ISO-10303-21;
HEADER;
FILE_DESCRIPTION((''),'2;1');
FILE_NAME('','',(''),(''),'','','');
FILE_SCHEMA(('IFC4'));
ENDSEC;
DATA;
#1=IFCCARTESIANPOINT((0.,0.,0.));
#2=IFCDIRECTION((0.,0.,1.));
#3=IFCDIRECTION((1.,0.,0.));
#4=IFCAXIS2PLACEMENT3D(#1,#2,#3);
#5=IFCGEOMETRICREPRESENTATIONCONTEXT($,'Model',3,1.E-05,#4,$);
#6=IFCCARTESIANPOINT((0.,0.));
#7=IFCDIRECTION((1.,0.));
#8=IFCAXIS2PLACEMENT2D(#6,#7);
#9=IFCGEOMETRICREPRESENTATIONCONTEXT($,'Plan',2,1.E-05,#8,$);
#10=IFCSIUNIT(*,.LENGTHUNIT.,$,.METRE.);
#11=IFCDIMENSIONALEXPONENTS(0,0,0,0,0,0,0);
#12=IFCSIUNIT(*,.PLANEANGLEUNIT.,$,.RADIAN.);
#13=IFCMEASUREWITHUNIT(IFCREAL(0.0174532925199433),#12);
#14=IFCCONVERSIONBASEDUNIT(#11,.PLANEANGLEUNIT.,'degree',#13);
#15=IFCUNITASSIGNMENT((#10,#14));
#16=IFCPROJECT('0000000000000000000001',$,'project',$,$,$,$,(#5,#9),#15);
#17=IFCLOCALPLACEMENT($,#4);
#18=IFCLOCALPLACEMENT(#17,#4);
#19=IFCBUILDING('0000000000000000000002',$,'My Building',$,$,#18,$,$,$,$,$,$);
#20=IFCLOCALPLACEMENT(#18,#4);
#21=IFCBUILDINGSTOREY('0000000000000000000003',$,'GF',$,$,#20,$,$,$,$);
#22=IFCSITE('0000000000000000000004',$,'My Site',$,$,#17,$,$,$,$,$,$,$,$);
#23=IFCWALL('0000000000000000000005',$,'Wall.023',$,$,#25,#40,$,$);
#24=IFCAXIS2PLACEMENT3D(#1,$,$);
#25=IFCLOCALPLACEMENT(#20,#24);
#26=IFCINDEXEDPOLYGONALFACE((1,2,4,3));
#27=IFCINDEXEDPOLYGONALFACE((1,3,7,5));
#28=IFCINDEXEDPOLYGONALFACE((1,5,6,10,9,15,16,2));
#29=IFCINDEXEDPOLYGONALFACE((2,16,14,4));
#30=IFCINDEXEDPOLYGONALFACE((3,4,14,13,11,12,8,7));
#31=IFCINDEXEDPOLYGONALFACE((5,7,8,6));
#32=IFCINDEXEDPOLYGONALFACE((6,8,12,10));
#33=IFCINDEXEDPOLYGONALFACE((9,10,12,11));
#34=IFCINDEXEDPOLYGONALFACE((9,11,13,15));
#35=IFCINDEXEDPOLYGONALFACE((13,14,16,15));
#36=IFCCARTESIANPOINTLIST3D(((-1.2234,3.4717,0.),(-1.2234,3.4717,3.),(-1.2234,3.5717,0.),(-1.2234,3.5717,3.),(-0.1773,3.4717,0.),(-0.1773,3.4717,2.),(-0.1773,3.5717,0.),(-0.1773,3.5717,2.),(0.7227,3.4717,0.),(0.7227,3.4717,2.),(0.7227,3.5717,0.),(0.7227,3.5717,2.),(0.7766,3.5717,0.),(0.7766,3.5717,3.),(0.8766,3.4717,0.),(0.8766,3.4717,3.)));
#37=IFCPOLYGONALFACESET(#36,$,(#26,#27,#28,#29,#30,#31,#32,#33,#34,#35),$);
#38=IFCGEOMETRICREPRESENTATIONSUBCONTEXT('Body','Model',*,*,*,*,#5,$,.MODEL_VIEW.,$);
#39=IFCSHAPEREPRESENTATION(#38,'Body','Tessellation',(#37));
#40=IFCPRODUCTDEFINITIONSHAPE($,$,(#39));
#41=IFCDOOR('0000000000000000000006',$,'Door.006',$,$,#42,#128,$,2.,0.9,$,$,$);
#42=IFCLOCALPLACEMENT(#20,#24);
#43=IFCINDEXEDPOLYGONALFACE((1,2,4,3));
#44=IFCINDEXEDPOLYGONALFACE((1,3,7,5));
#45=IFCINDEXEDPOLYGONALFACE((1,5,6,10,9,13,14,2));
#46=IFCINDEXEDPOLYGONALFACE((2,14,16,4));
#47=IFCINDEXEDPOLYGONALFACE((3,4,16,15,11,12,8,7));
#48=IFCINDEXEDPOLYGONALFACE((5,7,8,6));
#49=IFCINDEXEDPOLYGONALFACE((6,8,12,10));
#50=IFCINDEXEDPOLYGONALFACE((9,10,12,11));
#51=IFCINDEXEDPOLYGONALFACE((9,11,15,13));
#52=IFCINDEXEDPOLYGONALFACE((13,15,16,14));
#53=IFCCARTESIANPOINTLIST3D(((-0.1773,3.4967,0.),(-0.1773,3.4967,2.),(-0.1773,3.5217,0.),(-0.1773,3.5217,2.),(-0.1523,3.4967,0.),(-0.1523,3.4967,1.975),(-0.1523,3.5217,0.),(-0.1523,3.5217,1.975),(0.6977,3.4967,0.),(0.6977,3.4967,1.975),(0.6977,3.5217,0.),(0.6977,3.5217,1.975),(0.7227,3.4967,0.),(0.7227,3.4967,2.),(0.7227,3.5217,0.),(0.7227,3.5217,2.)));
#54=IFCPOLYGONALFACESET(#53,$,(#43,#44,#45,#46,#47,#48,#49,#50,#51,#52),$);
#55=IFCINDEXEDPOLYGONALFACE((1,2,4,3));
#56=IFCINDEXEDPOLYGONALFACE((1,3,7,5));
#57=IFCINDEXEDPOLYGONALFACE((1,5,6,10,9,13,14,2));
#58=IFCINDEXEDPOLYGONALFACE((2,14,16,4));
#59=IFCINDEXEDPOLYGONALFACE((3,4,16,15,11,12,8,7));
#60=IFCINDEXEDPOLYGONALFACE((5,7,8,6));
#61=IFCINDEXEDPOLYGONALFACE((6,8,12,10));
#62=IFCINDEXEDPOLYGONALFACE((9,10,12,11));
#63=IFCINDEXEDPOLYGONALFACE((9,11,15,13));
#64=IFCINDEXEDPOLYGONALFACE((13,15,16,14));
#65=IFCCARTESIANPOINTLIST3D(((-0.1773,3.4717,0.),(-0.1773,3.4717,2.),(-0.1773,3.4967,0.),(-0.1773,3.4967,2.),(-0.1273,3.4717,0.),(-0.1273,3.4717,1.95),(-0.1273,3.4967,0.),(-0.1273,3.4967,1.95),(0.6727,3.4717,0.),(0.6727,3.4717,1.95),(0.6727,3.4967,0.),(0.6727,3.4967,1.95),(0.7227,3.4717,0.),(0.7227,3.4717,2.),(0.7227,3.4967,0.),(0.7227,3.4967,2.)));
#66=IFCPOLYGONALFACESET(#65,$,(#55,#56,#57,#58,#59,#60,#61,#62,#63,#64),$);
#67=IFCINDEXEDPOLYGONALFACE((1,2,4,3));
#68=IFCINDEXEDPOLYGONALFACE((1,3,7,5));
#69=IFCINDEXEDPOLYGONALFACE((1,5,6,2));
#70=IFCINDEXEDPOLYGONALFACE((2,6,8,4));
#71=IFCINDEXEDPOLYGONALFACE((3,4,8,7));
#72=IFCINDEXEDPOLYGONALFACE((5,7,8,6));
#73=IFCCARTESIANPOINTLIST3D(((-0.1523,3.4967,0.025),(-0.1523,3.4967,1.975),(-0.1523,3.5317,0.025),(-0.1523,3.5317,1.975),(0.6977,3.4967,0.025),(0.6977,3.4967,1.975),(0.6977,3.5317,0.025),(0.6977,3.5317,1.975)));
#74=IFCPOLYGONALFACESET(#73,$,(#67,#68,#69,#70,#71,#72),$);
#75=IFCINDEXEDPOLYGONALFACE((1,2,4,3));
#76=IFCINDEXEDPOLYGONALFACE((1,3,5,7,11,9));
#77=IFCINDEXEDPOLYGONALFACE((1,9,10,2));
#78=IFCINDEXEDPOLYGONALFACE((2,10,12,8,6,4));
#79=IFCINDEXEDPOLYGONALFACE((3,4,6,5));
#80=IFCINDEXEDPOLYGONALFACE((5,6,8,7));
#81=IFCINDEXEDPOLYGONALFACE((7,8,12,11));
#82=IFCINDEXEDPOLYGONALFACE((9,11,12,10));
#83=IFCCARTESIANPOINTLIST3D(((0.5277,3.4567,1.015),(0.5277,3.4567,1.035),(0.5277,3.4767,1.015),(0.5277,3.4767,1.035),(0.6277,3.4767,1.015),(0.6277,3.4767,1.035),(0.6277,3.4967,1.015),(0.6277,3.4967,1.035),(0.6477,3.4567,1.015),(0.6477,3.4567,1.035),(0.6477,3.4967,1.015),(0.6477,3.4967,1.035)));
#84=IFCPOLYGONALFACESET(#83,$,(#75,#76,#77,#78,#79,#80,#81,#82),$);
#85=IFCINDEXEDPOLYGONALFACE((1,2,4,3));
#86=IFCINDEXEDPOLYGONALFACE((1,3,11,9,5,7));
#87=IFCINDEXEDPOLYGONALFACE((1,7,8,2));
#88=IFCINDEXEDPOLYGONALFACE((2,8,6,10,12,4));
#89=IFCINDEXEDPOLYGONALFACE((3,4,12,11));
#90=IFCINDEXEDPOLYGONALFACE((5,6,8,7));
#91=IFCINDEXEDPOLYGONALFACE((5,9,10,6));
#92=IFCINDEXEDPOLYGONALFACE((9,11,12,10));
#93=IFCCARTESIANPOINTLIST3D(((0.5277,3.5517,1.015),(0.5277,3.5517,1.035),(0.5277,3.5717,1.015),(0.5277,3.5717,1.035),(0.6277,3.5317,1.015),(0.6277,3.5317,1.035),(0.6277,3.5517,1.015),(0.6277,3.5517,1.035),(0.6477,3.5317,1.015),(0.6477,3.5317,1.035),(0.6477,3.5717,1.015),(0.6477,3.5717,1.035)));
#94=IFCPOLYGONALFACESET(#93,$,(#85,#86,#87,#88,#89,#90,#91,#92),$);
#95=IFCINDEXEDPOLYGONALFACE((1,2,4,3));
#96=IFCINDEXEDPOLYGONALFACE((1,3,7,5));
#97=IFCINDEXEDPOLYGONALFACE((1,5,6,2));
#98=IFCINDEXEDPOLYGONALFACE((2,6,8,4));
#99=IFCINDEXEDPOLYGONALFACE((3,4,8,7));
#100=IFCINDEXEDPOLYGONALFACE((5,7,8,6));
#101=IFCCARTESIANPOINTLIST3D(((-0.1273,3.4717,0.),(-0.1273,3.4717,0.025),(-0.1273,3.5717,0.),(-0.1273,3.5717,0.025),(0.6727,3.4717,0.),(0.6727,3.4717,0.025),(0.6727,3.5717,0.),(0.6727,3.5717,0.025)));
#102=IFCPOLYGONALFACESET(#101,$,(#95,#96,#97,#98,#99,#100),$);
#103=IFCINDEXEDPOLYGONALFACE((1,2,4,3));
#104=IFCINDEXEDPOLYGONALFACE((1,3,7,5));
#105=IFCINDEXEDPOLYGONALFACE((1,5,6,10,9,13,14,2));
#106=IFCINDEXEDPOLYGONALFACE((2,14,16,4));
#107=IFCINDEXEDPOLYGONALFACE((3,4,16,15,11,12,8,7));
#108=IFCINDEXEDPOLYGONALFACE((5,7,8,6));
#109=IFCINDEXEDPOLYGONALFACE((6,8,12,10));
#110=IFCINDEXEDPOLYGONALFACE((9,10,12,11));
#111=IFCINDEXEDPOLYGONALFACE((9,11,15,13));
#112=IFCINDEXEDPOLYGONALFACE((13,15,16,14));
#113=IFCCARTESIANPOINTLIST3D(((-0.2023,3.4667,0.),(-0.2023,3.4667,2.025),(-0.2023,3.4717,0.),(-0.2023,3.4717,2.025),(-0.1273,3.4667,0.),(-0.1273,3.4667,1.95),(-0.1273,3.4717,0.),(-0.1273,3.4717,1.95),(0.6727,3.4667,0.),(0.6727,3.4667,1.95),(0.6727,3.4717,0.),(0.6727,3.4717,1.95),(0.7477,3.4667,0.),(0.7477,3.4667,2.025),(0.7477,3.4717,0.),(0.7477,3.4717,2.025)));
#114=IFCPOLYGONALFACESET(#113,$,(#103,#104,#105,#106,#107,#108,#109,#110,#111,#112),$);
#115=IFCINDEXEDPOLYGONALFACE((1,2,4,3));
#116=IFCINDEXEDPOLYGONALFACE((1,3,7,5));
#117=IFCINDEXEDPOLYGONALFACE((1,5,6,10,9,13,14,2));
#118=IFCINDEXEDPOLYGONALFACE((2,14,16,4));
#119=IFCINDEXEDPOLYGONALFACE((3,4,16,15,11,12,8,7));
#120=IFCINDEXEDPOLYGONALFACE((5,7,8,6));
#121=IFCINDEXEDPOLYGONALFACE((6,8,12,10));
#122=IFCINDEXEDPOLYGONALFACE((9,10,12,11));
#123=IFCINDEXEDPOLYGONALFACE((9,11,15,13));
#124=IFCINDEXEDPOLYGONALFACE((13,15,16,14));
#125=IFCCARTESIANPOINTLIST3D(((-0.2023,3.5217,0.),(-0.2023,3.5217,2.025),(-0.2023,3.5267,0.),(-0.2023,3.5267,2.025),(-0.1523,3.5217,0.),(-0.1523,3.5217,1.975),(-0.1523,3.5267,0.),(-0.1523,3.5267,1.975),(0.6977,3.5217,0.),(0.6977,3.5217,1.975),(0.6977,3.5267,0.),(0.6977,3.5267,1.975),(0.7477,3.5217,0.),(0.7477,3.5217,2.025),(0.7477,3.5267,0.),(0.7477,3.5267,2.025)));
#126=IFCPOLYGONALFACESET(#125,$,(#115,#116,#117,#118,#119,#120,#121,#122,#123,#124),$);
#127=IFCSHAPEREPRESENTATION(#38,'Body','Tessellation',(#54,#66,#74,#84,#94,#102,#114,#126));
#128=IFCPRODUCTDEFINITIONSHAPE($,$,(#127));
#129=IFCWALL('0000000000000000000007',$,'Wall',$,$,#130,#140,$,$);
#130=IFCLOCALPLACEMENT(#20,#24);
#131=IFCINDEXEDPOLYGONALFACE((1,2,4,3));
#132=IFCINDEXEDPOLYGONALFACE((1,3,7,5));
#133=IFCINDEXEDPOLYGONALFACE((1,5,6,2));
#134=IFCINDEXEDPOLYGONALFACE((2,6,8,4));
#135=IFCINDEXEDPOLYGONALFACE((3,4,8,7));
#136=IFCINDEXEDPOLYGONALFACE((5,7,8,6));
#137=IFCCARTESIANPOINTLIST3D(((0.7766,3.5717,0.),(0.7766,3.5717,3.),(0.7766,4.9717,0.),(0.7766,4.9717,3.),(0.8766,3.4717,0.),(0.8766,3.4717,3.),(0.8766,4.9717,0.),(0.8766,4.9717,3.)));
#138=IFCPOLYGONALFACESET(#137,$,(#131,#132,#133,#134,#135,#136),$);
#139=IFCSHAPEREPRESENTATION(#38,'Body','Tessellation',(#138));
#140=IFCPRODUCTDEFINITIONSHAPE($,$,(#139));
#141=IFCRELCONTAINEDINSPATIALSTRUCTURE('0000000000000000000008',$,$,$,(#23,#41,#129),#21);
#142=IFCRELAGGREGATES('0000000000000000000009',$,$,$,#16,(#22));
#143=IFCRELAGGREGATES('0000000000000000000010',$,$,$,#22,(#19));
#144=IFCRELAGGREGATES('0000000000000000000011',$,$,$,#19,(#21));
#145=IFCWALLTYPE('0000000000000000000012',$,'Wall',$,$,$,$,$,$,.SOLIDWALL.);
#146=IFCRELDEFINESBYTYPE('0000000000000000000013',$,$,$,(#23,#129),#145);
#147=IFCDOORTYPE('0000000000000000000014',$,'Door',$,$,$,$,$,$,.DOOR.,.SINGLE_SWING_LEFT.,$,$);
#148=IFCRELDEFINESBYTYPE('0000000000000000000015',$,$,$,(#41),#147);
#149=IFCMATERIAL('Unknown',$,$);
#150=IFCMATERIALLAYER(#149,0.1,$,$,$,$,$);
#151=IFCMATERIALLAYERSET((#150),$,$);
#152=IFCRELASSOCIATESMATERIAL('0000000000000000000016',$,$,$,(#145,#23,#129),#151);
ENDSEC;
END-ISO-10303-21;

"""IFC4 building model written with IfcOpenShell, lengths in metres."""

from ifc_helpers import new_model, entity, si_unit, converted_unit, frame, origin_with_axes, origin_2d_with_axis, place, context, subcontext, project, spatial, line, indexed_curve, outline, extrude, shape, source, transform, mapped, material, layer, layer_set, layer_usage, type_object, type_shapes, element, fill, save


model = new_model("IFC4")

# Units and contexts
model_context = context("Model", 3, precision=1e-05, world=origin_with_axes())
plan_context = context("Plan", 2, precision=1e-05, world=origin_2d_with_axis())
body_context_1 = subcontext(model_context, "Body", "Model", "MODEL_VIEW")
body_context_2 = subcontext(plan_context, "Body", "Plan", "PLAN_VIEW")
ifc_project = project(units=[si_unit("LENGTHUNIT", "METRE"), converted_unit("PLANEANGLEUNIT", "degree", entity("IfcReal", 0.0174532925199433), si_unit("PLANEANGLEUNIT", "RADIAN"), dimensions=[0, 0, 0, 0, 0, 0, 0])], contexts=[model_context, plan_context])

# Site, building, storey
site_placement = place(None, origin_with_axes())
site = spatial("IfcSite", under=ifc_project, at=site_placement, Name="My Site")
building_placement = place(site_placement, origin_with_axes())
building = spatial("IfcBuilding", under=site, at=building_placement, Name="My Building")
storey_placement = place(building_placement, origin_with_axes())
storey = spatial("IfcBuildingStorey", under=building, at=storey_placement, Name="GF")

# Shared definitions
ifc_material = material(Name="Unknown")

# Shared definitions
ifc_layer = layer(ifc_material, 0.1)
ifc_layer_set = layer_set([ifc_layer])
wall_type = type_object("IfcWallType", Name="Wall", PredefinedType="SOLIDWALL", material=ifc_layer_set)

# Shared definitions
shared_shape_1 = source(origin_with_axes(), body_context_1, "Body", "SweptSolid", [
    extrude(outline(indexed_curve([(0.0, 0.0), (0.9, 0.0), (0.9, 2.0), (0.0, 2.0)], segments=[line(1, 2, 3, 4, 1)])), frame((0.0, -0.6, 0.0), z_axis=(0.0, -1.0, 0.0), x_axis=(1.0, 0.0, 0.0)), (0.0, 0.0, -1.0), 1.2),
])
door_type = type_object("IfcDoorType", Name="Door", OperationType="SINGLE_SWING_LEFT", PredefinedType="DOOR")
shared_shape_2 = source(origin_with_axes(), body_context_1, "Body", "SweptSolid", [
    extrude(outline(indexed_curve([(0.0, 0.0), (0.0, 2.0), (0.9, 2.0), (0.9, 0.0), (0.875, 0.0), (0.875, 1.975), (0.025, 1.975), (0.025, 0.0)], segments=[line(1, 2, 3, 4, 5, 6, 7, 8, 1)])), frame((0.0, 0.025, 0.0), z_axis=(0.0, -1.0, 0.0), x_axis=(1.0, 0.0, 0.0)), (0.0, 0.0, -1.0), 0.025),
    extrude(outline(indexed_curve([(0.0, 0.0), (0.0, 2.0), (0.9, 2.0), (0.9, 0.0), (0.85, 0.0), (0.85, 1.95), (0.05, 1.95), (0.05, 0.0)], segments=[line(1, 2, 3, 4, 5, 6, 7, 8, 1)])), frame((0.0, 0.0, 0.0), z_axis=(0.0, -1.0, 0.0), x_axis=(1.0, 0.0, 0.0)), (0.0, 0.0, -1.0), 0.025),
    extrude(outline(indexed_curve([(0.0, 0.0), (0.85, 0.0), (0.85, 0.035), (0.0, 0.035)], segments=[line(1, 2, 3, 4, 1)])), frame((0.025, 0.025, 0.025), z_axis=(0.0, 0.0, 1.0), x_axis=(1.0, 0.0, 0.0)), (0.0, 0.0, 1.0), 1.95),
    extrude(outline(indexed_curve([(0.0, 0.0), (0.0, -0.04), (-0.12, -0.04), (-0.12, -0.02), (-0.02, -0.02), (-0.02, 0.0)], segments=[line(1, 2, 3, 4, 5, 6, 1)])), frame((0.825, 0.025, 1.015), z_axis=(0.0, 0.0, 1.0), x_axis=(1.0, 0.0, 0.0)), (0.0, 0.0, 1.0), 0.02),
    extrude(outline(indexed_curve([(0.0, 0.0), (0.0, 0.04), (-0.12, 0.04), (-0.12, 0.02), (-0.02, 0.02), (-0.02, 0.0)], segments=[line(1, 2, 3, 4, 5, 6, 1)])), frame((0.825, 0.06, 1.015), z_axis=(0.0, 0.0, 1.0), x_axis=(1.0, 0.0, 0.0)), (0.0, 0.0, 1.0), 0.02),
    extrude(outline(indexed_curve([(0.0, 0.0), (0.8, 0.0), (0.8, 0.1), (0.0, 0.1)], segments=[line(1, 2, 3, 4, 1)])), frame((0.05, 0.0, 0.0), z_axis=(0.0, 0.0, 1.0), x_axis=(1.0, 0.0, 0.0)), (0.0, 0.0, 1.0), 0.025),
    extrude(outline(indexed_curve([(0.0, 0.0), (0.0, 2.025), (0.95, 2.025), (0.95, 0.0), (0.875, 0.0), (0.875, 1.95), (0.075, 1.95), (0.075, 0.0)], segments=[line(1, 2, 3, 4, 5, 6, 7, 8, 1)])), frame((-0.025, -0.005, 0.0), z_axis=(0.0, -1.0, 0.0), x_axis=(1.0, 0.0, 0.0)), (0.0, 0.0, -1.0), 0.005),
    extrude(outline(indexed_curve([(0.0, 0.0), (0.0, 2.025), (0.95, 2.025), (0.95, 0.0), (0.9, 0.0), (0.9, 1.975), (0.05, 1.975), (0.05, 0.0)], segments=[line(1, 2, 3, 4, 5, 6, 7, 8, 1)])), frame((-0.025, 0.05, 0.0), z_axis=(0.0, -1.0, 0.0), x_axis=(1.0, 0.0, 0.0)), (0.0, 0.0, -1.0), 0.005),
])
shared_shape_3 = source(origin_with_axes(), body_context_2, "Body", "Curve2D", [
    entity("IfcIndexedPolyCurve", entity("IfcCartesianPointList2D", [[0.0, 0.0], [0.0, 0.05], [0.025, 0.05], [0.025, 0.025], [0.05, 0.025], [0.05, 0.0]]), [entity("IfcLineIndex", [1, 2, 3, 4, 5, 6, 1])]),
    entity("IfcIndexedPolyCurve", entity("IfcCartesianPointList2D", [[0.9, 0.0], [0.9, 0.05], [0.875, 0.05], [0.875, 0.025], [0.85, 0.025], [0.85, 0.0]]), [entity("IfcLineIndex", [1, 2, 3, 4, 5, 6, 1])]),
    entity("IfcTrimmedCurve", entity("IfcEllipse", entity("IfcAxis2Placement2D", entity("IfcCartesianPoint", [0.06, 0.05]), entity("IfcDirection", [1.0, 0.0])), 0.815, 0.85), [entity("IfcCartesianPoint", [0.875, 0.05])], [entity("IfcCartesianPoint", [0.06, 0.9])], True, "CARTESIAN"),
    entity("IfcIndexedPolyCurve", entity("IfcCartesianPointList2D", [[0.025, 0.05], [0.06, 0.05], [0.06, 0.9], [0.025, 0.9]]), [entity("IfcLineIndex", [1, 2, 3, 4, 1])]),
])
type_shapes(door_type, [shared_shape_2, shared_shape_3])

# Wall, opening, door
ifc_layer_usage_1 = layer_usage(ifc_layer_set, "AXIS2", "POSITIVE", 0.0)
wall_1_placement = place(storey_placement, frame((-1.2234, 3.4717, 0.0), z_axis=(0.0, 0.0, 1.0), x_axis=(1.0, 0.0, 0.0)))
wall_1 = element("IfcWall", 1, at=wall_1_placement, inside=storey, type_object=wall_type, material=ifc_layer_usage_1, Name="Wall.023", context=body_context_1, shape_type="SweptSolid", body=[
    extrude(outline(indexed_curve([(0.0, 0.0), (0.0, 0.1), (2.0, 0.1), (2.1, 0.0)], segments=[line(1, 2, 3, 4, 1)])), origin_with_axes(), (0.0, 0.0, 1.0), 3.0),
])
opening_1_placement = place(wall_1_placement, frame((1.046, 0.0, 0.0), z_axis=(0.0, 0.0, 1.0), x_axis=(1.0, 0.0, 0.0)))
opening_1 = element("IfcOpeningElement", 2, at=opening_1_placement, cuts=wall_1, PredefinedType="OPENING", context=body_context_1, shape_type="MappedRepresentation", body=[
    mapped(shared_shape_1, transform((0.0, 0.0, 0.0), x_axis=(1.0, 0.0, 0.0), y_axis=(0.0, 1.0, 0.0), z_axis=(0.0, 0.0, 1.0), scale=1.0)),
])
door_1_placement = place(opening_1_placement, origin_with_axes())
door_1 = element("IfcDoor", 3, at=door_1_placement, inside=storey, type_object=door_type, Name="Door.006", OverallHeight=2.0, OverallWidth=0.9, shapes=[
    shape(body_context_1, "Body", "MappedRepresentation", [mapped(shared_shape_2, transform((0.0, 0.0, 0.0), x_axis=(1.0, 0.0, 0.0), y_axis=(0.0, 1.0, 0.0), z_axis=(0.0, 0.0, 1.0), scale=1.0))]),
    shape(body_context_2, "Body", "MappedRepresentation", [mapped(shared_shape_3, transform((0.0, 0.0, 0.0), x_axis=(1.0, 0.0, 0.0), y_axis=(0.0, 1.0, 0.0), z_axis=(0.0, 0.0, 1.0), scale=1.0))]),
])
fill(opening_1, door_1)

# Wall
ifc_layer_usage_2 = layer_usage(ifc_layer_set, "AXIS2", "POSITIVE", 0.0)
wall_2_placement = place(storey_placement, frame((0.8766, 3.4717, 0.0), z_axis=(0.0, 0.0, 1.0), x_axis=(0.0, 1.0, 0.0)))
element("IfcWall", 4, at=wall_2_placement, inside=storey, type_object=wall_type, material=ifc_layer_usage_2, Name="Wall", context=body_context_1, shape_type="SweptSolid", body=[
    extrude(outline(indexed_curve([(0.0, 0.0), (0.1, 0.1), (1.5, 0.1), (1.5, 0.0)], segments=[line(1, 2, 3, 4, 1)])), origin_with_axes(), (0.0, 0.0, 1.0), 3.0),
])

save(model, "model.ifc")
